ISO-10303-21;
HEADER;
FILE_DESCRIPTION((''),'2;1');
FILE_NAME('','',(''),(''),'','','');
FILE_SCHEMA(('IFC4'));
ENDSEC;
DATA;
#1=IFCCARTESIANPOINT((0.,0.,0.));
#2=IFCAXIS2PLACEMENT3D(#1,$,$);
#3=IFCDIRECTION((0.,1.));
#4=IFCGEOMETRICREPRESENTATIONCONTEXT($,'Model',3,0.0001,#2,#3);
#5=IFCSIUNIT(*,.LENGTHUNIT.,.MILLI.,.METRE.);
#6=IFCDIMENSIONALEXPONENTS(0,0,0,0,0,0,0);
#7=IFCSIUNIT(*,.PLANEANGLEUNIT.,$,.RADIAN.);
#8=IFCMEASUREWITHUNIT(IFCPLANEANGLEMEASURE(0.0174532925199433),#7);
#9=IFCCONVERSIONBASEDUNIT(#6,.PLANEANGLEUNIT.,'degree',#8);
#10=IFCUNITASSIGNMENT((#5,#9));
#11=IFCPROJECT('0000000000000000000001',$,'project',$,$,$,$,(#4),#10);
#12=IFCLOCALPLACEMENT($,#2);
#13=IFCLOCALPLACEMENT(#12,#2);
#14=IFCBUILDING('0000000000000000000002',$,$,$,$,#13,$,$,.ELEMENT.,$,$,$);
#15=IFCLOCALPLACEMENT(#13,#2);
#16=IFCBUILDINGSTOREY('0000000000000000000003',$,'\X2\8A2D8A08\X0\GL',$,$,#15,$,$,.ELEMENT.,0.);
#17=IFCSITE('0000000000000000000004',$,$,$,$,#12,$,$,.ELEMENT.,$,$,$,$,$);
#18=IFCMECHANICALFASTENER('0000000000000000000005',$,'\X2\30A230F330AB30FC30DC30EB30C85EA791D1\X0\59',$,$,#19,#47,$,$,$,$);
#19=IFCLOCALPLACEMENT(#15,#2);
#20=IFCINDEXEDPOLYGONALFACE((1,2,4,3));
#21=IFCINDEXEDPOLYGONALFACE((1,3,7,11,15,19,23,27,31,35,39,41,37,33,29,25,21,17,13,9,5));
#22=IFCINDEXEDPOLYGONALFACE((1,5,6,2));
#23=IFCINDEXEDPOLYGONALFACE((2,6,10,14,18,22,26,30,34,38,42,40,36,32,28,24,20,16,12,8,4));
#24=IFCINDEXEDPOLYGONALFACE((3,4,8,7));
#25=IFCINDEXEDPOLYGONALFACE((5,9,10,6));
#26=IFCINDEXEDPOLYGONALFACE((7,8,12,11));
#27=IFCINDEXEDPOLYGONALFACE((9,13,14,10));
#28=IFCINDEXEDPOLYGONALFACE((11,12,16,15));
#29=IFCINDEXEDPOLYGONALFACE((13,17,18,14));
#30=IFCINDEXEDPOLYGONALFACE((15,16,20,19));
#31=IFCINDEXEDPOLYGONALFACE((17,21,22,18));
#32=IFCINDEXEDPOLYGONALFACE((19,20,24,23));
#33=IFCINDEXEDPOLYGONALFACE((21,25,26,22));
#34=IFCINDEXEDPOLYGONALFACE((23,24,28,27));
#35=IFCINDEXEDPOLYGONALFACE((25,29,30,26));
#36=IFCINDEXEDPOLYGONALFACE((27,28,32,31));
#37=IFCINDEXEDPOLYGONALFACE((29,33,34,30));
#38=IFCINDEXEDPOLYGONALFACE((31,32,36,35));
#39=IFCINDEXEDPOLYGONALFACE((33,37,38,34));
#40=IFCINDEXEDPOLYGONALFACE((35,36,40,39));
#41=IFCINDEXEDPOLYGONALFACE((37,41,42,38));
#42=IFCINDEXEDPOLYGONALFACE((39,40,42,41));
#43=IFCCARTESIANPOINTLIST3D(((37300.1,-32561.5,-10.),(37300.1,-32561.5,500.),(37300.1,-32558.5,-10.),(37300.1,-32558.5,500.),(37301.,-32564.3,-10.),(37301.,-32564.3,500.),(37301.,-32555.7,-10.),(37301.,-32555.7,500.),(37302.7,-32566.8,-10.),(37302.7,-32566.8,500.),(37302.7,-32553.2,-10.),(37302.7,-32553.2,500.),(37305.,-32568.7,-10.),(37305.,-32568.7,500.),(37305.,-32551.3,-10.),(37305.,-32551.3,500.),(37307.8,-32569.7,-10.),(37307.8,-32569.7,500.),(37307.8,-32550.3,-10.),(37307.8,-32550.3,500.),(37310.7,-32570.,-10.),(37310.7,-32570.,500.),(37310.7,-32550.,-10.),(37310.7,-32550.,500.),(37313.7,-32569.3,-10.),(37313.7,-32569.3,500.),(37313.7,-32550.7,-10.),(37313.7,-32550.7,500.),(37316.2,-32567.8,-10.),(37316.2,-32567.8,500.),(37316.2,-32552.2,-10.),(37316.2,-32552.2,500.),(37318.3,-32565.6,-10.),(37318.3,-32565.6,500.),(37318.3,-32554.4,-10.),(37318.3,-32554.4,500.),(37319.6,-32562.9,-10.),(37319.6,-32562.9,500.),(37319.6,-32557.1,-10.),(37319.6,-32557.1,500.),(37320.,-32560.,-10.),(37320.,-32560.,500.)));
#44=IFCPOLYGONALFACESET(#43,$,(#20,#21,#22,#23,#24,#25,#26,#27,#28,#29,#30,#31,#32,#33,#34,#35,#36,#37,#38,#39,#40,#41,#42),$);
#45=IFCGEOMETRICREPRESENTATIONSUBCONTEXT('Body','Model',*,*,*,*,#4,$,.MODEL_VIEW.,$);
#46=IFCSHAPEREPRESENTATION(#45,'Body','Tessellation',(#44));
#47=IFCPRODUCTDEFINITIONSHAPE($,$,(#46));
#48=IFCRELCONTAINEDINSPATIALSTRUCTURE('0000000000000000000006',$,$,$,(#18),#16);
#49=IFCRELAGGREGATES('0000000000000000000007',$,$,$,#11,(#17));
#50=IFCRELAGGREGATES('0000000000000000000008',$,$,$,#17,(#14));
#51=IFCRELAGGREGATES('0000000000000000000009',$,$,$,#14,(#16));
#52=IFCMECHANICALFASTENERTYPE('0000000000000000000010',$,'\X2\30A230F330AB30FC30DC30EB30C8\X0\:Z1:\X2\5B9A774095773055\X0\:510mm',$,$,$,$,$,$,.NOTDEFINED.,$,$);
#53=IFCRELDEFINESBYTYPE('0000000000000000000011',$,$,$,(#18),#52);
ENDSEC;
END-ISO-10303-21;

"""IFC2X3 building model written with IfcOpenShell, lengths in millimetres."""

from ifc_helpers import new_model, entity, si_unit, converted_unit, direction, frame, origin, origin_with_axes, origin_2d, place, context, subcontext, project, spatial, circle, extrude, type_object, element, save


model = new_model("IFC2X3")

# Units and contexts
model_context = context("Model", 3, precision=0.0001, world=origin(), true_north=direction((0.0, 1.0)))
body_context = subcontext(model_context, "Body", "Model", "MODEL_VIEW")
ifc_project = project(units=[si_unit("LENGTHUNIT", "METRE", prefix="MILLI"), converted_unit("PLANEANGLEUNIT", "degree", entity("IfcPlaneAngleMeasure", 0.0174532925199433), si_unit("PLANEANGLEUNIT", "RADIAN"), dimensions=[0, 0, 0, 0, 0, 0, 0])], contexts=[model_context])

# Site, building, storey
site_placement = place(None, origin())
site = spatial("IfcSite", under=ifc_project, at=site_placement, CompositionType="ELEMENT")
building_placement = place(site_placement, origin())
building = spatial("IfcBuilding", under=site, at=building_placement, CompositionType="ELEMENT")
storey_placement = place(building_placement, origin())
storey = spatial("IfcBuildingStorey", under=building, at=storey_placement, Name="設計GL", CompositionType="ELEMENT", Elevation=0.0)

# Mechanical fastener
mechanical_fastener_type_1 = type_object("IfcMechanicalFastenerType", Name="アンカーボルト:Z1:定着長さ:510mm")
mechanical_fastener_1_placement = place(storey_placement, frame((37310.0, -32560.0, -10.0)))
element("IfcMechanicalFastener", 1, at=mechanical_fastener_1_placement, inside=storey, type_object=mechanical_fastener_type_1, Name="アンカーボルト座金59", context=body_context, shape_type="SweptSolid", body=[
    extrude(circle(Radius=10.0, at=origin_2d()), origin_with_axes(), (0.0, 0.0, 1.0), 510.0),
])

save(model, "model.ifc")
